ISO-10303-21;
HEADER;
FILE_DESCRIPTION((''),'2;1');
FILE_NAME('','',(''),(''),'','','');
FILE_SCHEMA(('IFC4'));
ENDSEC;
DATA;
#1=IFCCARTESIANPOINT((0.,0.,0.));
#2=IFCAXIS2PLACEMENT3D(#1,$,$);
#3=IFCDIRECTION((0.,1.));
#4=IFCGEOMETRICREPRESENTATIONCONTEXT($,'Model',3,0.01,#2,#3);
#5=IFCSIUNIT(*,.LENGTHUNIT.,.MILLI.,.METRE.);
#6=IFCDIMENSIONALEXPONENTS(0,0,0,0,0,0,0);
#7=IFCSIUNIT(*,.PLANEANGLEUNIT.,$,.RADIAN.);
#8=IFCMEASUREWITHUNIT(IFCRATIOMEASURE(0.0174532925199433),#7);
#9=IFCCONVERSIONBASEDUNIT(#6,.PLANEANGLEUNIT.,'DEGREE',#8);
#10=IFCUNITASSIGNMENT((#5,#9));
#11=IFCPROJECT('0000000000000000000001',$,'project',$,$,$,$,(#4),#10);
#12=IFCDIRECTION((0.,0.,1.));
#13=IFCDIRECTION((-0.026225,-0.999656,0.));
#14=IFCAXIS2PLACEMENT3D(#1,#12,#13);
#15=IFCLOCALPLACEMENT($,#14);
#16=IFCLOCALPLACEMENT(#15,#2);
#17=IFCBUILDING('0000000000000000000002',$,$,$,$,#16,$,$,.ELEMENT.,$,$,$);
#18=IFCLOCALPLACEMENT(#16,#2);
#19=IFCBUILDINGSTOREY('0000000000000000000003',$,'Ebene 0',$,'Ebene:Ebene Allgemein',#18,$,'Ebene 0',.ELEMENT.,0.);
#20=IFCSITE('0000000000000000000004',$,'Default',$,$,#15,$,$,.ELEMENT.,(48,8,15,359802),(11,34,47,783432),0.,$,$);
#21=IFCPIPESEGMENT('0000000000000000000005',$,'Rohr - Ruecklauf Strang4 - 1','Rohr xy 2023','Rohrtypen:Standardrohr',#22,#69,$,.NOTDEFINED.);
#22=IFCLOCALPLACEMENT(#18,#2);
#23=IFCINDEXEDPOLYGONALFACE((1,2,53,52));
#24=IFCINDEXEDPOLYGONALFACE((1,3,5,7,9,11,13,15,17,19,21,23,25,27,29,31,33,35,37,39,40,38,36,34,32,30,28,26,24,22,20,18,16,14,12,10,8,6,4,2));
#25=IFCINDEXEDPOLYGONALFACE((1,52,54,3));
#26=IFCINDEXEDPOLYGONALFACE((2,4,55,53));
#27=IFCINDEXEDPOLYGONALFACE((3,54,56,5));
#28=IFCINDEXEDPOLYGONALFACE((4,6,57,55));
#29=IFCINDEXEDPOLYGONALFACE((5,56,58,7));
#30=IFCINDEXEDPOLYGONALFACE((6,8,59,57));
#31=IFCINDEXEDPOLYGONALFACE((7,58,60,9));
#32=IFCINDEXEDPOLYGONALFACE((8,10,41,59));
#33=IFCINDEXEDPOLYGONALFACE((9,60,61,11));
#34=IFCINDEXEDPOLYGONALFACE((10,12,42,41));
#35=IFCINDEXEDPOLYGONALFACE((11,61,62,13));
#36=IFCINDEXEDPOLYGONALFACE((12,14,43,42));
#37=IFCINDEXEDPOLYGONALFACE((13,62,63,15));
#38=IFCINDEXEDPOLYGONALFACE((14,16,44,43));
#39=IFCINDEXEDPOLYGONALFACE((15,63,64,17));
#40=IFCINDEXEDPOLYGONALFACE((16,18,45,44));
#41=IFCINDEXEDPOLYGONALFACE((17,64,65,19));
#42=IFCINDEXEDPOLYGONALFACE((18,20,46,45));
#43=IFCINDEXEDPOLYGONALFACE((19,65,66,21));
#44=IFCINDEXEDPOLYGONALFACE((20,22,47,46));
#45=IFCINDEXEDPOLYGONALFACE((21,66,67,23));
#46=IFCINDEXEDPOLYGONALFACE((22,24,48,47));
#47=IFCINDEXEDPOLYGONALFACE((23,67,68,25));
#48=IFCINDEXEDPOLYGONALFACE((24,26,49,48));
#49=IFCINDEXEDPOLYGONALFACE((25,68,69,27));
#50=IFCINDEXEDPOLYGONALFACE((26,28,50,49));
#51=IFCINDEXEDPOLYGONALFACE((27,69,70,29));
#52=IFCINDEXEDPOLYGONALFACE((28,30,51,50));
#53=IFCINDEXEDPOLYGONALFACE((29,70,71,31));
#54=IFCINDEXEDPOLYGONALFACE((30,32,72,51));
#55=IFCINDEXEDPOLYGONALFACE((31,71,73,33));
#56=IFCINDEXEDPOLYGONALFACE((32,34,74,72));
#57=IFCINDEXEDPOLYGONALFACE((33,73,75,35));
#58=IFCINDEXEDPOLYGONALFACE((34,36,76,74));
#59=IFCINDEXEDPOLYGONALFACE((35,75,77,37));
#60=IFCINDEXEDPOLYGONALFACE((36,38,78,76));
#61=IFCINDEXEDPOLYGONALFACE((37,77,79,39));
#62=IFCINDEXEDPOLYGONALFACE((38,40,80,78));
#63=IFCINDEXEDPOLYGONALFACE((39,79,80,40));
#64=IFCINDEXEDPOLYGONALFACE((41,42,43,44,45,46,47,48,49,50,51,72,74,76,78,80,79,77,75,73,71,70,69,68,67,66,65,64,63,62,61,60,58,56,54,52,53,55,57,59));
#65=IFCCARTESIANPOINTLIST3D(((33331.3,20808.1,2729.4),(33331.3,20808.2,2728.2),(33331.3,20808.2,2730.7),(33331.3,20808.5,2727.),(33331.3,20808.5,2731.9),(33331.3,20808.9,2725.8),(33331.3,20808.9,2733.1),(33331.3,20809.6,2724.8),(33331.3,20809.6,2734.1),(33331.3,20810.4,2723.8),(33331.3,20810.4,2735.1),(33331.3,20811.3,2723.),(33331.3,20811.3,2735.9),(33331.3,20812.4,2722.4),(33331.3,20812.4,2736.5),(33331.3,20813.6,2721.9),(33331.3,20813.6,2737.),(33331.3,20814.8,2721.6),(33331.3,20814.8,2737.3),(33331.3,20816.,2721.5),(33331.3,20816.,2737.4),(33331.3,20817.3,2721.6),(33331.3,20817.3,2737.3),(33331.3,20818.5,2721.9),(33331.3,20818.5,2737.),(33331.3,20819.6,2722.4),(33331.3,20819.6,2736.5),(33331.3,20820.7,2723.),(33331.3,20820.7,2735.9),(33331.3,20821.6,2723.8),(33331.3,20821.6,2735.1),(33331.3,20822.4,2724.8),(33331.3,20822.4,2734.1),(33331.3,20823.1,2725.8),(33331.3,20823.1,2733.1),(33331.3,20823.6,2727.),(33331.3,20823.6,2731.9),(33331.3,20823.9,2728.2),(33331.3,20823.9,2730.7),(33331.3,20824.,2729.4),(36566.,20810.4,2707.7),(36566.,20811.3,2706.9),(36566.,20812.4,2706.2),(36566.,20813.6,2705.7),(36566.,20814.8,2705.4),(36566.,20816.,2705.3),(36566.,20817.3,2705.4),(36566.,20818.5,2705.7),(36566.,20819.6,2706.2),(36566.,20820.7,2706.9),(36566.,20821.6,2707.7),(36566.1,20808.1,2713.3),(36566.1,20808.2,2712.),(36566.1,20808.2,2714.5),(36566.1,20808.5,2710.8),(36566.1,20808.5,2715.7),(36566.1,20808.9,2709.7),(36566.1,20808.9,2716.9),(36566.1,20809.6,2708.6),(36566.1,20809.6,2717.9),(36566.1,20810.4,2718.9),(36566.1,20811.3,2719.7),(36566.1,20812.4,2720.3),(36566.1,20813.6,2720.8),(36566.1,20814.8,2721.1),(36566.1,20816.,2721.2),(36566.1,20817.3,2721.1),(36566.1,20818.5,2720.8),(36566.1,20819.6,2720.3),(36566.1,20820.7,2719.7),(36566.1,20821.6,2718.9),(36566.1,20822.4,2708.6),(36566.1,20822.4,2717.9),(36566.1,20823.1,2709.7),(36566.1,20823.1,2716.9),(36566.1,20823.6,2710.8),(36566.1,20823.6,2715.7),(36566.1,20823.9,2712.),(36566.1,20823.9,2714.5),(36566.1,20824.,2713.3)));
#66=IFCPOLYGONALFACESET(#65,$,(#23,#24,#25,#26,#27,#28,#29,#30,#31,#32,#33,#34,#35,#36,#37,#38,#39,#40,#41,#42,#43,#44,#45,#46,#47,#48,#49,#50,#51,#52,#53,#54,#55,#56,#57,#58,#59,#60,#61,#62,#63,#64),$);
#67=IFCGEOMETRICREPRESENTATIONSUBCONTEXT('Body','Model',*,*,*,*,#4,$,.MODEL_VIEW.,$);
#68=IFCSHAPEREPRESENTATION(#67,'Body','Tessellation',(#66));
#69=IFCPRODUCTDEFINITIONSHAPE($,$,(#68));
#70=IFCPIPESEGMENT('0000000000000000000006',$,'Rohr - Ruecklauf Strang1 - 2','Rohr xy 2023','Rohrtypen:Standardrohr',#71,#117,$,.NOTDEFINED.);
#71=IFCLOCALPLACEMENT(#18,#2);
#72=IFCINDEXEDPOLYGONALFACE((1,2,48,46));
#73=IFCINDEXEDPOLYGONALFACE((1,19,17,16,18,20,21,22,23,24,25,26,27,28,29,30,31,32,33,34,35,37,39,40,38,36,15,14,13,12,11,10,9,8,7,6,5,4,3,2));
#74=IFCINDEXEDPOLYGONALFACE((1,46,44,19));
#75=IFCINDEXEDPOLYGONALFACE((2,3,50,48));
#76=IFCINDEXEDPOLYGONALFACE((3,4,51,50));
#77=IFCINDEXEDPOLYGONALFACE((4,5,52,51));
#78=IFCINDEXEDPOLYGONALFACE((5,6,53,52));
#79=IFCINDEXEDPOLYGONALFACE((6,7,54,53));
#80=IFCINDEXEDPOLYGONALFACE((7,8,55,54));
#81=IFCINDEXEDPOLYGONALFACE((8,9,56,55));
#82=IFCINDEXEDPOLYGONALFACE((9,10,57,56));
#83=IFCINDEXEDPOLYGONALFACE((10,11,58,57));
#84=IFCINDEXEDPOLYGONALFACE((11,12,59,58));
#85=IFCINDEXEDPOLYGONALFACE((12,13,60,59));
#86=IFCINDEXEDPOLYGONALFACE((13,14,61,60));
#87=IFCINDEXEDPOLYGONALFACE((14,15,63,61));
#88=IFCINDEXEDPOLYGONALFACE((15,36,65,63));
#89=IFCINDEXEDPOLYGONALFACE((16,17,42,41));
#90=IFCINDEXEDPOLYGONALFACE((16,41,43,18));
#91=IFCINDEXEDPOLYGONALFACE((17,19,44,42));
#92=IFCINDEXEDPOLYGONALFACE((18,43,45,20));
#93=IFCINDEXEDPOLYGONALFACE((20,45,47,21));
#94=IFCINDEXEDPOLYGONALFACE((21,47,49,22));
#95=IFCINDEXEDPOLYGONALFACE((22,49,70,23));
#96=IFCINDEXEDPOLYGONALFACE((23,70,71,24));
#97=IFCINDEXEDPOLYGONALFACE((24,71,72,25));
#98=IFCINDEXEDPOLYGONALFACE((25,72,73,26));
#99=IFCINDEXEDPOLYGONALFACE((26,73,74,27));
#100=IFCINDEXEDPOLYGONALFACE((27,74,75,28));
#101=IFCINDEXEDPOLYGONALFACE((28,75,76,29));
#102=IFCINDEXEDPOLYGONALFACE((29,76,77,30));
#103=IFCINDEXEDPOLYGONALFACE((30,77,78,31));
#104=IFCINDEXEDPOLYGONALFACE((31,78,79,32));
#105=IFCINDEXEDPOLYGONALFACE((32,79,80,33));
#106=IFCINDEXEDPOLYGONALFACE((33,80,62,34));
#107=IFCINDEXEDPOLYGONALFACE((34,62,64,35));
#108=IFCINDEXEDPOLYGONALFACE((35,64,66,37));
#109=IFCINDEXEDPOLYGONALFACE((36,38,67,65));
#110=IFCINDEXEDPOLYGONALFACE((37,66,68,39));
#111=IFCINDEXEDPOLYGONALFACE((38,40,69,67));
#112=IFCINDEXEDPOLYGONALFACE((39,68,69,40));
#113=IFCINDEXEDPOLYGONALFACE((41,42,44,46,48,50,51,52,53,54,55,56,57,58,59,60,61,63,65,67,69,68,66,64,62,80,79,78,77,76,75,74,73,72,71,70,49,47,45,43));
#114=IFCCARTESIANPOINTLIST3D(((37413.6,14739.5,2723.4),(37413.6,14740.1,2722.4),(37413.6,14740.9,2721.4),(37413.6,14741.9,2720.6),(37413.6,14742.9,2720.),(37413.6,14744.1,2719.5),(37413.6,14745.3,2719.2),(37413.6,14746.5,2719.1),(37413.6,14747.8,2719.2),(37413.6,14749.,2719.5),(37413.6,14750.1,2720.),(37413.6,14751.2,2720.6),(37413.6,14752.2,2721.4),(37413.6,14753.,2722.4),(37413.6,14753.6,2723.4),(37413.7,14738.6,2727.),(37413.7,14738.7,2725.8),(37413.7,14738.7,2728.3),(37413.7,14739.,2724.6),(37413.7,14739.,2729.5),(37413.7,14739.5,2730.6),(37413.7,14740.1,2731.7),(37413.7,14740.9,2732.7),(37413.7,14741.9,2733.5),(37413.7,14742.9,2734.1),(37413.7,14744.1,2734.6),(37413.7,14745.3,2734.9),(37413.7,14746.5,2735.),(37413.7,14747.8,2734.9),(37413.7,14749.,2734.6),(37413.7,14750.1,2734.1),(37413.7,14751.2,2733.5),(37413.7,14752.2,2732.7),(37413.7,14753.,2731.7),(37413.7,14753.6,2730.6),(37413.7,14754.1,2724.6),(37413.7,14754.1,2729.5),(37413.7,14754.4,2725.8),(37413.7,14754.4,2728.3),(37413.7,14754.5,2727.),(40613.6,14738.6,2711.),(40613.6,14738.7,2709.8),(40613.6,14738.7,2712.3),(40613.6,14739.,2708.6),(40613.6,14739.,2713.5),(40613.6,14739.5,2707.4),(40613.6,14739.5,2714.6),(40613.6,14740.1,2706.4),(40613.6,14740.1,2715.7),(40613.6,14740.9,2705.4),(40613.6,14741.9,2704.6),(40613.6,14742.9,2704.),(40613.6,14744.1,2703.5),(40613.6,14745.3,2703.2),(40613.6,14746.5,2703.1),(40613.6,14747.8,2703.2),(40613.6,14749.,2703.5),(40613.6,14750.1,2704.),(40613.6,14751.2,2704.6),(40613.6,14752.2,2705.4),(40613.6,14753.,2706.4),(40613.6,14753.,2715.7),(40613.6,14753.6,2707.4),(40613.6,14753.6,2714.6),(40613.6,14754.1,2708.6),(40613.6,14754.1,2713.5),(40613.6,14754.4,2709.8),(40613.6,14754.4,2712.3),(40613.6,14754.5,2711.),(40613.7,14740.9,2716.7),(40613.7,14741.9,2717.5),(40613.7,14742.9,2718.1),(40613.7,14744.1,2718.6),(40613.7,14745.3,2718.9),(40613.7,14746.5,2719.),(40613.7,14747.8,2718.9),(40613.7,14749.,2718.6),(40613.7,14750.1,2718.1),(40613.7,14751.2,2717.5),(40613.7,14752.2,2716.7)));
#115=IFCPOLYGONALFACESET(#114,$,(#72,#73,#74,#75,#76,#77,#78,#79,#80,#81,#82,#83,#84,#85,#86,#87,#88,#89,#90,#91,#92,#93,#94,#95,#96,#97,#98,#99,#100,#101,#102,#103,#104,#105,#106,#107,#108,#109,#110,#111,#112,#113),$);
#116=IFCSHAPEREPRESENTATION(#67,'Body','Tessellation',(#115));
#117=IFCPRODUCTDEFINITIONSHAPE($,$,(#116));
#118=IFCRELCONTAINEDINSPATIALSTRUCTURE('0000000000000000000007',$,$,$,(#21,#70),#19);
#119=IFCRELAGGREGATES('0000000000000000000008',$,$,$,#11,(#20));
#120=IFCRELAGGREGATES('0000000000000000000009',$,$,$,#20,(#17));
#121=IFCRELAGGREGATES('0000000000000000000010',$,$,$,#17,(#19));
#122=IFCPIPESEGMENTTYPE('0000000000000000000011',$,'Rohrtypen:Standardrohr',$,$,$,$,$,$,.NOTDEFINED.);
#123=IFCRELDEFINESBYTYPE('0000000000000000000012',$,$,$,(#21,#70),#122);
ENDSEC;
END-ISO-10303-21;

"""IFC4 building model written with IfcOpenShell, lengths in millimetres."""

from ifc_helpers import new_model, entity, si_unit, converted_unit, direction, frame, origin, place, context, subcontext, project, spatial, indexed_curve, outline, extrude, type_object, element, save


model = new_model("IFC4")

# Units and contexts
model_context = context("Model", 3, precision=0.01, world=origin(), true_north=direction((0.0, 1.0)))
body_context = subcontext(model_context, "Body", "Model", "MODEL_VIEW")
ifc_project = project(units=[si_unit("LENGTHUNIT", "METRE", prefix="MILLI"), converted_unit("PLANEANGLEUNIT", "DEGREE", entity("IfcRatioMeasure", 0.0174532925199433), si_unit("PLANEANGLEUNIT", "RADIAN"), dimensions=[0, 0, 0, 0, 0, 0, 0])], contexts=[model_context])

# Site, building, storey
site_placement = place(None, frame((0.0, 0.0, 0.0), z_axis=(0.0, 0.0, 1.0), x_axis=(-0.026225, -0.999656, 0.0)))
site = spatial("IfcSite", under=ifc_project, at=site_placement, Name="Default", CompositionType="ELEMENT", RefLatitude=(48, 8, 15, 359802), RefLongitude=(11, 34, 47, 783432), RefElevation=0.0)
building_placement = place(site_placement, origin())
building = spatial("IfcBuilding", under=site, at=building_placement, CompositionType="ELEMENT")
storey_placement = place(building_placement, origin())
storey = spatial("IfcBuildingStorey", under=building, at=storey_placement, Name="Ebene 0", ObjectType="Ebene:Ebene Allgemein", LongName="Ebene 0", CompositionType="ELEMENT", Elevation=0.0)

# Pipe segments
pipe_segment_type = type_object("IfcPipeSegmentType", Name="Rohrtypen:Standardrohr", PredefinedType="NOTDEFINED")
pipe_segment_1_placement = place(storey_placement, origin())
element("IfcPipeSegment", 1, at=pipe_segment_1_placement, inside=storey, type_object=pipe_segment_type, Name="Rohr - Ruecklauf Strang4 - 1", Description="Rohr xy 2023", ObjectType="Rohrtypen:Standardrohr", PredefinedType="NOTDEFINED", context=body_context, shape_type="SweptSolid", body=[
    extrude(outline(indexed_curve([(7.9, 0.0), (7.8, 1.2), (7.6, 2.5), (7.1, 3.6), (6.4, 4.7), (5.6, 5.6), (4.7, 6.4), (3.6, 7.1), (2.5, 7.6), (1.2, 7.8), (0.0, 7.9), (-1.2, 7.8), (-2.5, 7.6), (-3.6, 7.1), (-4.7, 6.4), (-5.6, 5.6), (-6.4, 4.7), (-7.1, 3.6), (-7.6, 2.5), (-7.8, 1.2), (-7.9, 0.0), (-7.8, -1.2), (-7.6, -2.5), (-7.1, -3.6), (-6.4, -4.7), (-5.6, -5.6), (-4.7, -6.4), (-3.6, -7.1), (-2.5, -7.6), (-1.2, -7.8), (0.0, -7.9), (1.2, -7.8), (2.5, -7.6), (3.6, -7.1), (4.7, -6.4), (5.6, -5.6), (6.4, -4.7), (7.1, -3.6), (7.6, -2.5), (7.8, -1.2), (7.9, 0.0)], self_intersect=False)), frame((36566.1, 20816.0, 2713.3), z_axis=(-0.999988, 0.0, 0.005), x_axis=(0.0, 1.0, 0.0)), (0.0, 0.0, 1.0), 3234.8),
])
pipe_segment_2_placement = place(storey_placement, origin())
element("IfcPipeSegment", 2, at=pipe_segment_2_placement, inside=storey, type_object=pipe_segment_type, Name="Rohr - Ruecklauf Strang1 - 2", Description="Rohr xy 2023", ObjectType="Rohrtypen:Standardrohr", PredefinedType="NOTDEFINED", context=body_context, shape_type="SweptSolid", body=[
    extrude(outline(indexed_curve([(7.9, 0.0), (7.8, 1.2), (7.6, 2.5), (7.1, 3.6), (6.4, 4.7), (5.6, 5.6), (4.7, 6.4), (3.6, 7.1), (2.5, 7.6), (1.2, 7.8), (0.0, 7.9), (-1.2, 7.8), (-2.5, 7.6), (-3.6, 7.1), (-4.7, 6.4), (-5.6, 5.6), (-6.4, 4.7), (-7.1, 3.6), (-7.6, 2.5), (-7.8, 1.2), (-7.9, 0.0), (-7.8, -1.2), (-7.6, -2.5), (-7.1, -3.6), (-6.4, -4.7), (-5.6, -5.6), (-4.7, -6.4), (-3.6, -7.1), (-2.5, -7.6), (-1.2, -7.8), (0.0, -7.9), (1.2, -7.8), (2.5, -7.6), (3.6, -7.1), (4.7, -6.4), (5.6, -5.6), (6.4, -4.7), (7.1, -3.6), (7.6, -2.5), (7.8, -1.2), (7.9, 0.0)], self_intersect=False)), frame((40613.6, 14746.5, 2711.0), z_axis=(-0.999988, 0.0, 0.005), x_axis=(0.0, 1.0, 0.0)), (0.0, 0.0, 1.0), 3200.0),
])

save(model, "model.ifc")
